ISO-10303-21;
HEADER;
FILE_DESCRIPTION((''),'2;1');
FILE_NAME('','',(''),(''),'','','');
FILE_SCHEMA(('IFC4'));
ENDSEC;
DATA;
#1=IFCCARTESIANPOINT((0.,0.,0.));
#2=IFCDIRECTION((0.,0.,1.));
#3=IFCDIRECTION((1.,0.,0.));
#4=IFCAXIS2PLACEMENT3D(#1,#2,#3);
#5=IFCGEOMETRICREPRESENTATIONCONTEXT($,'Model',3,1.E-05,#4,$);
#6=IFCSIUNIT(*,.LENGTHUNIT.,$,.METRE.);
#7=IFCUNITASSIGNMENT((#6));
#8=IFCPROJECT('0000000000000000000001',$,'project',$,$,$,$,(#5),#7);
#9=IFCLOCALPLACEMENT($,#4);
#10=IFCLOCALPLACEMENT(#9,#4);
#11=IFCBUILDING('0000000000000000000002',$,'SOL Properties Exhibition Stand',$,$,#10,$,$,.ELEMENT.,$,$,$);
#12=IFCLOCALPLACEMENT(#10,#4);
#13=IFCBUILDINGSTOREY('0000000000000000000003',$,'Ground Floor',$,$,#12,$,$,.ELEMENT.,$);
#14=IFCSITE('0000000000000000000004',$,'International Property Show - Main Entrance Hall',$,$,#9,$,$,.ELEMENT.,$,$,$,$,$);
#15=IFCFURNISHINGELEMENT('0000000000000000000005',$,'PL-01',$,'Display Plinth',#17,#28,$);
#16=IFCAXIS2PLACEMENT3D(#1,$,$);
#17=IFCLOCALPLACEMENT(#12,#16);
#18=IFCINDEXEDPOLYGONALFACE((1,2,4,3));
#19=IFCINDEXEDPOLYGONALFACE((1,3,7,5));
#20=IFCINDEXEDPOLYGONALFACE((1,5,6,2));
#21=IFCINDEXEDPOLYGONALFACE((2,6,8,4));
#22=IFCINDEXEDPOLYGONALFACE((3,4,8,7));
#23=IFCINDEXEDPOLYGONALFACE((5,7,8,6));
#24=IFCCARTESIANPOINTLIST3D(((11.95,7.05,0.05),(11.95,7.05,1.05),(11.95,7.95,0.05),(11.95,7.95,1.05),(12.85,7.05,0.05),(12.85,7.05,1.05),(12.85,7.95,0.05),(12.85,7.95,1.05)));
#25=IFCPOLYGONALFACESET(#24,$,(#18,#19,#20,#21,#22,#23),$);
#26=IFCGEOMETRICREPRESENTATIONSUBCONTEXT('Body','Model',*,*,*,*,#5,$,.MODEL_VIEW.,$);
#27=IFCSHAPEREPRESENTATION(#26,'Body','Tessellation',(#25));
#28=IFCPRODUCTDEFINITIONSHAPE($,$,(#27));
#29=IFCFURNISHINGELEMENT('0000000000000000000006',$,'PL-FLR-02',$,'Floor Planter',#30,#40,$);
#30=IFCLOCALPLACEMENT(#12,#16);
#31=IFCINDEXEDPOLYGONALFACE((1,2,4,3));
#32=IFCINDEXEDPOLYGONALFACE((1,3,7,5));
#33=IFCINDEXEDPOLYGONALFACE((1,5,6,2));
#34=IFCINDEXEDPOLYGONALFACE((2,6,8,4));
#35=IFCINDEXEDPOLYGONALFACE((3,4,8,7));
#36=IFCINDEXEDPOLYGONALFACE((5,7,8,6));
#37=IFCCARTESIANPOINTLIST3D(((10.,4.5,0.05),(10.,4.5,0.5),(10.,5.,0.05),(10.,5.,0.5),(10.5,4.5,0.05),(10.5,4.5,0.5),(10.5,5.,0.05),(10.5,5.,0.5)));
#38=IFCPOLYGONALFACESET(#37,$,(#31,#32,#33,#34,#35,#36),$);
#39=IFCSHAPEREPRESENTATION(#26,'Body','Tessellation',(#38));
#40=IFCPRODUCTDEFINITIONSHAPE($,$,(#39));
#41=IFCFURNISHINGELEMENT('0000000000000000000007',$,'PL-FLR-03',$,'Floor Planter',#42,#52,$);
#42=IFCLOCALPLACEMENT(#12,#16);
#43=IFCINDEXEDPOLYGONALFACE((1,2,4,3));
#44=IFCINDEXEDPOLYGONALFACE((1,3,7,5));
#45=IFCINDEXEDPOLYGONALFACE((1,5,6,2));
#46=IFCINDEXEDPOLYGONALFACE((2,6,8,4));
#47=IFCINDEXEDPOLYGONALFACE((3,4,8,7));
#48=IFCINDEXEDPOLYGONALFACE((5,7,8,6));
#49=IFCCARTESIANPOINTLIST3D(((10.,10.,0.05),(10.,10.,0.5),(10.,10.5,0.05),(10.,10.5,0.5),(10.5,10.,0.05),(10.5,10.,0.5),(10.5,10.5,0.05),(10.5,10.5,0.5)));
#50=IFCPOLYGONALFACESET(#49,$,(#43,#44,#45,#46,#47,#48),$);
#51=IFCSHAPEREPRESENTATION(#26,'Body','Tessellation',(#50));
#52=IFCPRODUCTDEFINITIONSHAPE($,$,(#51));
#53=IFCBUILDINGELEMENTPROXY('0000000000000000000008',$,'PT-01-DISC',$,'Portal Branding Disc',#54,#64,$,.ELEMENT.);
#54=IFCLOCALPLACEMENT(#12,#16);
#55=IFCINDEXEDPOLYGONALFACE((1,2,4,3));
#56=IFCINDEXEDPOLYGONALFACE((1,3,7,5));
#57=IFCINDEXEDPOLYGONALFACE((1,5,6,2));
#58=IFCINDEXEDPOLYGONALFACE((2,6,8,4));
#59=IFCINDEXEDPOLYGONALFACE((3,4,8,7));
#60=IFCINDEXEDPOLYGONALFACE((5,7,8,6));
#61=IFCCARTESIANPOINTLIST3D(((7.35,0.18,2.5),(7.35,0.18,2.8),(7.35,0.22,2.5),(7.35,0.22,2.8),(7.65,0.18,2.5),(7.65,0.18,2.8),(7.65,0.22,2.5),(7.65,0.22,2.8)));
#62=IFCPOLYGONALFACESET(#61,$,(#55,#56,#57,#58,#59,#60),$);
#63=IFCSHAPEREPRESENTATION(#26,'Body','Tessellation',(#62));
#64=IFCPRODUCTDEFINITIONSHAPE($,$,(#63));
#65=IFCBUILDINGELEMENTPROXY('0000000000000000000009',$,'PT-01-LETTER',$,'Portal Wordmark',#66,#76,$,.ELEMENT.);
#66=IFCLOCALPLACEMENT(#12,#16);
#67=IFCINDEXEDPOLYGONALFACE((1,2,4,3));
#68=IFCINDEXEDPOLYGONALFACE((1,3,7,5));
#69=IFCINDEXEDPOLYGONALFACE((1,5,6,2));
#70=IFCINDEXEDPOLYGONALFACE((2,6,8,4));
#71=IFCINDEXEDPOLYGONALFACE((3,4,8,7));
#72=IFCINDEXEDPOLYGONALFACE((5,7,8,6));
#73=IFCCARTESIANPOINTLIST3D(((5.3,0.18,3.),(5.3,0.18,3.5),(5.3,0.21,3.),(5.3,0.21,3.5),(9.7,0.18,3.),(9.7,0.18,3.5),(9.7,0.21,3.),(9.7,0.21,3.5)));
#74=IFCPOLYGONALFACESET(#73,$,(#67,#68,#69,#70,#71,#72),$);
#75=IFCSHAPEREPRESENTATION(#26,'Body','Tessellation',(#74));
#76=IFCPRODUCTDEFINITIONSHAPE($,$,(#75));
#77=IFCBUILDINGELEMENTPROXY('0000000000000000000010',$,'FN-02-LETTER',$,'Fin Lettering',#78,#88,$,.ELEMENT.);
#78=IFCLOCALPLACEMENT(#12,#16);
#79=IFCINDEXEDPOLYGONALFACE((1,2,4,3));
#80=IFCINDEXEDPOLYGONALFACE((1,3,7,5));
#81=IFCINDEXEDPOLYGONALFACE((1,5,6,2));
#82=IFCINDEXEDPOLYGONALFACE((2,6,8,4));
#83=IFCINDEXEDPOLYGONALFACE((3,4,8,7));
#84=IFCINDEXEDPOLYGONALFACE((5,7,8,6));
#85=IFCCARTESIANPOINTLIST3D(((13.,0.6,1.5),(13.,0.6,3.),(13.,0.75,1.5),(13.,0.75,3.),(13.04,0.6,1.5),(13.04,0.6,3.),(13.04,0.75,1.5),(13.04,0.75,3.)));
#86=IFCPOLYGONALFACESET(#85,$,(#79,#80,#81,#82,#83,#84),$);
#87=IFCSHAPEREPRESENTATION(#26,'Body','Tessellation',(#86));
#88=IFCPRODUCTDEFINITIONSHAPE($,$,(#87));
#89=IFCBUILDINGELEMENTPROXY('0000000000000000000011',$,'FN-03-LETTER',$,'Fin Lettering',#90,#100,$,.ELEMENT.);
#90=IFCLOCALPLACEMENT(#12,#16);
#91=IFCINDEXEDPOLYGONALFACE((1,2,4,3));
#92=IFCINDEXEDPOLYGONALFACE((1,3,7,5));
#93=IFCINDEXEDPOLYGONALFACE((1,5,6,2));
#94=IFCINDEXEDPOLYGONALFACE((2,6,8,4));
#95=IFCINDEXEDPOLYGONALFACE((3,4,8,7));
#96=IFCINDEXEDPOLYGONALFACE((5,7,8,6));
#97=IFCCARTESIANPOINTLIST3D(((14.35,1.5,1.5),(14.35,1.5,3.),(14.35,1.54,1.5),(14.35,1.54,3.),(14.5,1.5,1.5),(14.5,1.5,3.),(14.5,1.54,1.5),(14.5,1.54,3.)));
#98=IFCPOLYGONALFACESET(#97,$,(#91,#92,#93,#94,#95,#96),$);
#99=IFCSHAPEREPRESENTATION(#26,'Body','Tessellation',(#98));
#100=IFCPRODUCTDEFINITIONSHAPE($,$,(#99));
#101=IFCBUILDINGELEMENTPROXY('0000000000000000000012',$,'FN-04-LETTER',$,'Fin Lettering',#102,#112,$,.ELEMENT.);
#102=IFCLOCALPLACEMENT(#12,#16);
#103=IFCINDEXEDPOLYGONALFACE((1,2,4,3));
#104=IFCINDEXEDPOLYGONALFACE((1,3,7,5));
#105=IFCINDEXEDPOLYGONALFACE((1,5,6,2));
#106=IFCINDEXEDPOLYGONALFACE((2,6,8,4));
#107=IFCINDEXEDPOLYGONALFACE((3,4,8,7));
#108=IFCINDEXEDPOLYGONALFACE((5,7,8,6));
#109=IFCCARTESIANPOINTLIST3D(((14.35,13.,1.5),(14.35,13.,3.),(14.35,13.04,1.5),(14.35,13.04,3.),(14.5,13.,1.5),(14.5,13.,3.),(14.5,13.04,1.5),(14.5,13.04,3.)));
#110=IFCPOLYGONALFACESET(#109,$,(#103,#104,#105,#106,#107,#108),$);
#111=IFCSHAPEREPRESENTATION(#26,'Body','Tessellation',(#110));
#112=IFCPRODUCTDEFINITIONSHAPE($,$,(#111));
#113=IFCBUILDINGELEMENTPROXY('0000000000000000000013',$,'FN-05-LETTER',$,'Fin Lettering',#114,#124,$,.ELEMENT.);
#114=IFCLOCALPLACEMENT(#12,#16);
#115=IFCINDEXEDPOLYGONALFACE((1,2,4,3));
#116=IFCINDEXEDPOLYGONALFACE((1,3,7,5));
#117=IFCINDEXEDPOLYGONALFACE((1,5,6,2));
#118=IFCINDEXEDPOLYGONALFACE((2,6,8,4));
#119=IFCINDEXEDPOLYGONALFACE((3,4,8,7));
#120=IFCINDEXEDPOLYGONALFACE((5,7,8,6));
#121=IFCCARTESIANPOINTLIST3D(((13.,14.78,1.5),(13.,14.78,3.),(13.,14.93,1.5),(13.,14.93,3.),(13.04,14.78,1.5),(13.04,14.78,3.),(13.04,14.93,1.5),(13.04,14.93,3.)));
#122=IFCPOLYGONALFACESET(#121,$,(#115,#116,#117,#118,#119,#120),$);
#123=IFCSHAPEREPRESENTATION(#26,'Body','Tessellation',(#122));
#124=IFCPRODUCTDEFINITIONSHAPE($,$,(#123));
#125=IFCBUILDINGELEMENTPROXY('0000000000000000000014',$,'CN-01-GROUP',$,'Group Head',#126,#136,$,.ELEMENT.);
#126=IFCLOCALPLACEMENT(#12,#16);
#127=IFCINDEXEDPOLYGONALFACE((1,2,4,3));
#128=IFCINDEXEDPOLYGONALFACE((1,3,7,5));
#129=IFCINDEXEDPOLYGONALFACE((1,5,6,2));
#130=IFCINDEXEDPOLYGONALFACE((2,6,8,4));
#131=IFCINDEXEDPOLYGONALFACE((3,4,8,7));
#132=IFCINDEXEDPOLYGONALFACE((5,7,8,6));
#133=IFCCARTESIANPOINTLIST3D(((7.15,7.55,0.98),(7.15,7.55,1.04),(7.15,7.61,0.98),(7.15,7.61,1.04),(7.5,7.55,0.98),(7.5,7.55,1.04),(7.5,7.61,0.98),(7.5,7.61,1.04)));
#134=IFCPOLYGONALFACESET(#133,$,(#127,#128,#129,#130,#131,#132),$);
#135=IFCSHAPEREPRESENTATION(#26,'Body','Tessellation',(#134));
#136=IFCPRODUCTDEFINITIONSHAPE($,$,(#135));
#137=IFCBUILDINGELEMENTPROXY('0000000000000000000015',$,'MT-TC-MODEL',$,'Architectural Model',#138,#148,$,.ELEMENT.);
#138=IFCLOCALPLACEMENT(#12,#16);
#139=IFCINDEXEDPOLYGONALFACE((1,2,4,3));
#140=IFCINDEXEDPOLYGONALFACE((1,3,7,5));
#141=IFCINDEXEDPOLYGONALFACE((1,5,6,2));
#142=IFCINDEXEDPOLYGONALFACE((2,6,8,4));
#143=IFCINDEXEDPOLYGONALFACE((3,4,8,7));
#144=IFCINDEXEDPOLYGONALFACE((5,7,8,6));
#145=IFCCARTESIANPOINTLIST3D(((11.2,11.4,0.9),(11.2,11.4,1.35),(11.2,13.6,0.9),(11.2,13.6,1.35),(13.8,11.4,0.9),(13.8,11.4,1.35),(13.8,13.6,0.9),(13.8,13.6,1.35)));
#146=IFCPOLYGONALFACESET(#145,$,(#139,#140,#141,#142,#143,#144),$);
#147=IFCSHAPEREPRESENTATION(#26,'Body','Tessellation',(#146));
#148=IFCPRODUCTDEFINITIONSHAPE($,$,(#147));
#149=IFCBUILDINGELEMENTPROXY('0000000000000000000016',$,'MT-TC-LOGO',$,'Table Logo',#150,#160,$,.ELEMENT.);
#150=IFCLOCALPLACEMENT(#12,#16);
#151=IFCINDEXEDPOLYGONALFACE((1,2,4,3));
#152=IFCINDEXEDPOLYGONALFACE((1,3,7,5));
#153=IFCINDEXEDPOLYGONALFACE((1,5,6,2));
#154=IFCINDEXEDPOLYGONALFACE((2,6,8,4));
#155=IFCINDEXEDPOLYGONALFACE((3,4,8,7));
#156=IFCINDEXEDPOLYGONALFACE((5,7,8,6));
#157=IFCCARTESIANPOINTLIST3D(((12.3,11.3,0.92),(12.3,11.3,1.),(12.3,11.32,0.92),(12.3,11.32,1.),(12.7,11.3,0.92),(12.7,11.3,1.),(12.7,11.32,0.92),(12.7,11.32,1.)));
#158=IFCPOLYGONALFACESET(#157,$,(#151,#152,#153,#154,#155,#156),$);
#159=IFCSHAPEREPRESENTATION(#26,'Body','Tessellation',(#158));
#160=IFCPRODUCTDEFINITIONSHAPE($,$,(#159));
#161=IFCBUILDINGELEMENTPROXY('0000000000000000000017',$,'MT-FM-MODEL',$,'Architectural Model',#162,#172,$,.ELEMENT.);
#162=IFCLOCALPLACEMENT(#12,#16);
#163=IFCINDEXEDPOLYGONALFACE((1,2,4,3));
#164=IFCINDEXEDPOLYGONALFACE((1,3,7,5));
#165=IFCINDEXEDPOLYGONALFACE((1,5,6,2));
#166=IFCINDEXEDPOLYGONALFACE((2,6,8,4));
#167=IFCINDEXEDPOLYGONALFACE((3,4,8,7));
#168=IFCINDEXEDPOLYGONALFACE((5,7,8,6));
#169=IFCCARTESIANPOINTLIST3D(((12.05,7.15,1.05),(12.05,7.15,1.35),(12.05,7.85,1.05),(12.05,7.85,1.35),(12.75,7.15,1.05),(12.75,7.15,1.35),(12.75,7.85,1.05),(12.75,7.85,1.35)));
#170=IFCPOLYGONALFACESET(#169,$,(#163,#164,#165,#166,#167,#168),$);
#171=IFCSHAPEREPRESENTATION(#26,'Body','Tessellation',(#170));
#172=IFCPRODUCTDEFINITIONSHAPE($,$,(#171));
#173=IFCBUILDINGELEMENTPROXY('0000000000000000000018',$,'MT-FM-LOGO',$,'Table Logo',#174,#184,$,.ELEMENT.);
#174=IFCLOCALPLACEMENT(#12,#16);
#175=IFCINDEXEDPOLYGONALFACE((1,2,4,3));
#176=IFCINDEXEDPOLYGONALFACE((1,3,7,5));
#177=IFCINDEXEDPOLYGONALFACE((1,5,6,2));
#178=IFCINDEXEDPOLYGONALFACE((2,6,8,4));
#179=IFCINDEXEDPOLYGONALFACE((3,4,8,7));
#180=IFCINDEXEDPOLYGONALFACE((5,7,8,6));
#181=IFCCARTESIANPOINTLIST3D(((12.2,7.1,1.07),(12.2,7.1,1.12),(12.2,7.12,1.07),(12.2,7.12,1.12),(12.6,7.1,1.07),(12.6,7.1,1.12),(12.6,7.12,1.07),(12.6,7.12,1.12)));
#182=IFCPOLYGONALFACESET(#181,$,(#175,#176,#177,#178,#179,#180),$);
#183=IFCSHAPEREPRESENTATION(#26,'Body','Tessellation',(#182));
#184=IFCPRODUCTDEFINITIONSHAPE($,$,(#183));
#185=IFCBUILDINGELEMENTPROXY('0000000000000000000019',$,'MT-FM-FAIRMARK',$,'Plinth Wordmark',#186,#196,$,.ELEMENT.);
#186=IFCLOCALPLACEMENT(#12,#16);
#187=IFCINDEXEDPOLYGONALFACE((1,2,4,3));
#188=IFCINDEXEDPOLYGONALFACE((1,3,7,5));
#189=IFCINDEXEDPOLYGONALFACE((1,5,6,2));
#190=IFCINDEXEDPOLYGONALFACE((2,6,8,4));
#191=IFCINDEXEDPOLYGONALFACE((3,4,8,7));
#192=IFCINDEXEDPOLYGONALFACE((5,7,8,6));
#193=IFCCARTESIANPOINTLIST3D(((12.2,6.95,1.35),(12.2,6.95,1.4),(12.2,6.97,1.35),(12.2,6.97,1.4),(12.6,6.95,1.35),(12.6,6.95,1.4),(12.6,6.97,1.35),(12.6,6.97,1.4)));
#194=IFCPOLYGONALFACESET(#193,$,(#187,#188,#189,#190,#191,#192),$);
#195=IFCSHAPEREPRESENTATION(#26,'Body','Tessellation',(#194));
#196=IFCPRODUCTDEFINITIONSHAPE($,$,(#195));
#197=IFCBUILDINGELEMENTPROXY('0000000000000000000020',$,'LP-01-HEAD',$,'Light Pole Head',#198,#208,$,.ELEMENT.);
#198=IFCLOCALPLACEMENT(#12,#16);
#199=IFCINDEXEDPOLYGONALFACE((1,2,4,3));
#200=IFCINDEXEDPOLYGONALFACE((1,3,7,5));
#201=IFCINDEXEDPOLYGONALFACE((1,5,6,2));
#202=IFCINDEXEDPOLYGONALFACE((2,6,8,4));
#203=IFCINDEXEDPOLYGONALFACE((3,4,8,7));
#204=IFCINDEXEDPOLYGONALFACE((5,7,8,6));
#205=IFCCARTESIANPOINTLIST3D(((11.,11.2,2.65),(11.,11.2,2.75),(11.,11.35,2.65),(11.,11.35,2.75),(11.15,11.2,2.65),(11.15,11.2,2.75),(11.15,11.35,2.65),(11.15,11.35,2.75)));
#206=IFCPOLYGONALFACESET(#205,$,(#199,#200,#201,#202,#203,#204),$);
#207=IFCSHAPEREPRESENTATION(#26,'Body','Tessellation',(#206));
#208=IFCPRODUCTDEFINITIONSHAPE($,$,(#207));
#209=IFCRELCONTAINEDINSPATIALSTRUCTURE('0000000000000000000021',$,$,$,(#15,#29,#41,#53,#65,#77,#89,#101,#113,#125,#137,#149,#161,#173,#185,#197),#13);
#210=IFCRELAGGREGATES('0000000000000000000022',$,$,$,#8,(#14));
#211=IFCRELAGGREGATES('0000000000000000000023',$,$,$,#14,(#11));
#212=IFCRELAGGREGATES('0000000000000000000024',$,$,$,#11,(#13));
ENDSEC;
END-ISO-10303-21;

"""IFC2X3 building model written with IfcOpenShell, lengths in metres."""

from ifc_helpers import new_model, si_unit, frame, frame_2d, origin, origin_with_axes, place, context, subcontext, project, spatial, rectangle, extrude, element, save


model = new_model("IFC2X3")

# Units and contexts
model_context = context("Model", 3, precision=1e-05, world=origin_with_axes())
body_context = subcontext(model_context, "Body", "Model", "MODEL_VIEW")
ifc_project = project(units=[si_unit("LENGTHUNIT", "METRE")], contexts=[model_context])

# Site, building, storey
site_placement = place(None, origin_with_axes())
site = spatial("IfcSite", under=ifc_project, at=site_placement, Name="International Property Show - Main Entrance Hall", CompositionType="ELEMENT")
building_placement = place(site_placement, origin_with_axes())
building = spatial("IfcBuilding", under=site, at=building_placement, Name="SOL Properties Exhibition Stand", CompositionType="ELEMENT")
storey_placement = place(building_placement, origin_with_axes())
storey = spatial("IfcBuildingStorey", under=building, at=storey_placement, Name="Ground Floor", CompositionType="ELEMENT")

# Furnishing elements
furnishing_1_placement = place(storey_placement, frame((11.95, 7.05, 0.05), z_axis=(0.0, 0.0, 1.0), x_axis=(1.0, 0.0, 0.0)))
element("IfcFurnishingElement", 1, at=furnishing_1_placement, inside=storey, Name="PL-01", ObjectType="Display Plinth", context=body_context, shape_type="SweptSolid", body=[
    extrude(rectangle(XDim=0.9, YDim=0.9, at=frame_2d((0.45, 0.45))), origin(), (0.0, 0.0, 1.0), 1.0),
])
for number, where, z_axis, x_axis, name in (
    (2, (10.0, 4.5, 0.05), (0.0, 0.0, 1.0), (1.0, 0.0, 0.0), "PL-FLR-02"),
    (3, (10.0, 10.0, 0.05), (0.0, 0.0, 1.0), (1.0, 0.0, 0.0), "PL-FLR-03"),
):
    element("IfcFurnishingElement", number, at=place(storey_placement, frame(where, z_axis=z_axis, x_axis=x_axis)), inside=storey, Name=name, ObjectType="Floor Planter", context=body_context, shape_type="SweptSolid", body=[
        extrude(rectangle(XDim=0.5, YDim=0.5, at=frame_2d((0.25, 0.25))), origin(), (0.0, 0.0, 1.0), 0.45),
    ])

# Building element proxies
proxy_1_placement = place(storey_placement, frame((7.35, 0.18, 2.5), z_axis=(0.0, 0.0, 1.0), x_axis=(1.0, 0.0, 0.0)))
element("IfcBuildingElementProxy", 4, at=proxy_1_placement, inside=storey, Name="PT-01-DISC", ObjectType="Portal Branding Disc", CompositionType="ELEMENT", context=body_context, shape_type="SweptSolid", body=[
    extrude(rectangle(XDim=0.3, YDim=0.04, at=frame_2d((0.15, 0.02))), origin(), (0.0, 0.0, 1.0), 0.3),
])
proxy_2_placement = place(storey_placement, frame((5.3, 0.18, 3.0), z_axis=(0.0, 0.0, 1.0), x_axis=(1.0, 0.0, 0.0)))
element("IfcBuildingElementProxy", 5, at=proxy_2_placement, inside=storey, Name="PT-01-LETTER", ObjectType="Portal Wordmark", CompositionType="ELEMENT", context=body_context, shape_type="SweptSolid", body=[
    extrude(rectangle(XDim=4.4, YDim=0.03, at=frame_2d((2.2, 0.015))), origin(), (0.0, 0.0, 1.0), 0.5),
])
proxy_3_placement = place(storey_placement, frame((13.0, 0.6, 1.5), z_axis=(0.0, 0.0, 1.0), x_axis=(1.0, 0.0, 0.0)))
element("IfcBuildingElementProxy", 6, at=proxy_3_placement, inside=storey, Name="FN-02-LETTER", ObjectType="Fin Lettering", CompositionType="ELEMENT", context=body_context, shape_type="SweptSolid", body=[
    extrude(rectangle(XDim=0.04, YDim=0.15, at=frame_2d((0.02, 0.075))), origin(), (0.0, 0.0, 1.0), 1.5),
])
for number, where, z_axis, x_axis, name in (
    (7, (14.35, 1.5, 1.5), (0.0, 0.0, 1.0), (1.0, 0.0, 0.0), "FN-03-LETTER"),
    (8, (14.35, 13.0, 1.5), (0.0, 0.0, 1.0), (1.0, 0.0, 0.0), "FN-04-LETTER"),
):
    element("IfcBuildingElementProxy", number, at=place(storey_placement, frame(where, z_axis=z_axis, x_axis=x_axis)), inside=storey, Name=name, ObjectType="Fin Lettering", CompositionType="ELEMENT", context=body_context, shape_type="SweptSolid", body=[
        extrude(rectangle(XDim=0.15, YDim=0.04, at=frame_2d((0.075, 0.02))), origin(), (0.0, 0.0, 1.0), 1.5),
    ])
proxy_4_placement = place(storey_placement, frame((13.0, 14.78, 1.5), z_axis=(0.0, 0.0, 1.0), x_axis=(1.0, 0.0, 0.0)))
element("IfcBuildingElementProxy", 9, at=proxy_4_placement, inside=storey, Name="FN-05-LETTER", ObjectType="Fin Lettering", CompositionType="ELEMENT", context=body_context, shape_type="SweptSolid", body=[
    extrude(rectangle(XDim=0.04, YDim=0.15, at=frame_2d((0.02, 0.075))), origin(), (0.0, 0.0, 1.0), 1.5),
])
proxy_5_placement = place(storey_placement, frame((7.15, 7.55, 0.98), z_axis=(0.0, 0.0, 1.0), x_axis=(1.0, 0.0, 0.0)))
element("IfcBuildingElementProxy", 10, at=proxy_5_placement, inside=storey, Name="CN-01-GROUP", ObjectType="Group Head", CompositionType="ELEMENT", context=body_context, shape_type="SweptSolid", body=[
    extrude(rectangle(XDim=0.35, YDim=0.06, at=frame_2d((0.175, 0.03))), origin(), (0.0, 0.0, 1.0), 0.06),
])
proxy_6_placement = place(storey_placement, frame((11.2, 11.4, 0.9), z_axis=(0.0, 0.0, 1.0), x_axis=(1.0, 0.0, 0.0)))
element("IfcBuildingElementProxy", 11, at=proxy_6_placement, inside=storey, Name="MT-TC-MODEL", ObjectType="Architectural Model", CompositionType="ELEMENT", context=body_context, shape_type="SweptSolid", body=[
    extrude(rectangle(XDim=2.6, YDim=2.2, at=frame_2d((1.3, 1.1))), origin(), (0.0, 0.0, 1.0), 0.45),
])
proxy_7_placement = place(storey_placement, frame((12.3, 11.3, 0.92), z_axis=(0.0, 0.0, 1.0), x_axis=(1.0, 0.0, 0.0)))
element("IfcBuildingElementProxy", 12, at=proxy_7_placement, inside=storey, Name="MT-TC-LOGO", ObjectType="Table Logo", CompositionType="ELEMENT", context=body_context, shape_type="SweptSolid", body=[
    extrude(rectangle(XDim=0.4, YDim=0.02, at=frame_2d((0.2, 0.01))), origin(), (0.0, 0.0, 1.0), 0.08),
])
proxy_8_placement = place(storey_placement, frame((12.05, 7.15, 1.05), z_axis=(0.0, 0.0, 1.0), x_axis=(1.0, 0.0, 0.0)))
element("IfcBuildingElementProxy", 13, at=proxy_8_placement, inside=storey, Name="MT-FM-MODEL", ObjectType="Architectural Model", CompositionType="ELEMENT", context=body_context, shape_type="SweptSolid", body=[
    extrude(rectangle(XDim=0.7, YDim=0.7, at=frame_2d((0.35, 0.35))), origin(), (0.0, 0.0, 1.0), 0.3),
])
proxy_9_placement = place(storey_placement, frame((12.2, 7.1, 1.07), z_axis=(0.0, 0.0, 1.0), x_axis=(1.0, 0.0, 0.0)))
element("IfcBuildingElementProxy", 14, at=proxy_9_placement, inside=storey, Name="MT-FM-LOGO", ObjectType="Table Logo", CompositionType="ELEMENT", context=body_context, shape_type="SweptSolid", body=[
    extrude(rectangle(XDim=0.4, YDim=0.02, at=frame_2d((0.2, 0.01))), origin(), (0.0, 0.0, 1.0), 0.05),
])
proxy_10_placement = place(storey_placement, frame((12.2, 6.95, 1.35), z_axis=(0.0, 0.0, 1.0), x_axis=(1.0, 0.0, 0.0)))
element("IfcBuildingElementProxy", 15, at=proxy_10_placement, inside=storey, Name="MT-FM-FAIRMARK", ObjectType="Plinth Wordmark", CompositionType="ELEMENT", context=body_context, shape_type="SweptSolid", body=[
    extrude(rectangle(XDim=0.4, YDim=0.02, at=frame_2d((0.2, 0.01))), origin(), (0.0, 0.0, 1.0), 0.05),
])
for number, where, z_axis, x_axis, name in (
    (16, (11.0, 11.2, 2.65), (0.0, 0.0, 1.0), (1.0, 0.0, 0.0), "LP-01-HEAD"),
):
    element("IfcBuildingElementProxy", number, at=place(storey_placement, frame(where, z_axis=z_axis, x_axis=x_axis)), inside=storey, Name=name, ObjectType="Light Pole Head", CompositionType="ELEMENT", context=body_context, shape_type="SweptSolid", body=[
        extrude(rectangle(XDim=0.15, YDim=0.15, at=frame_2d((0.075, 0.075))), origin(), (0.0, 0.0, 1.0), 0.1),
    ])

save(model, "model.ifc")
